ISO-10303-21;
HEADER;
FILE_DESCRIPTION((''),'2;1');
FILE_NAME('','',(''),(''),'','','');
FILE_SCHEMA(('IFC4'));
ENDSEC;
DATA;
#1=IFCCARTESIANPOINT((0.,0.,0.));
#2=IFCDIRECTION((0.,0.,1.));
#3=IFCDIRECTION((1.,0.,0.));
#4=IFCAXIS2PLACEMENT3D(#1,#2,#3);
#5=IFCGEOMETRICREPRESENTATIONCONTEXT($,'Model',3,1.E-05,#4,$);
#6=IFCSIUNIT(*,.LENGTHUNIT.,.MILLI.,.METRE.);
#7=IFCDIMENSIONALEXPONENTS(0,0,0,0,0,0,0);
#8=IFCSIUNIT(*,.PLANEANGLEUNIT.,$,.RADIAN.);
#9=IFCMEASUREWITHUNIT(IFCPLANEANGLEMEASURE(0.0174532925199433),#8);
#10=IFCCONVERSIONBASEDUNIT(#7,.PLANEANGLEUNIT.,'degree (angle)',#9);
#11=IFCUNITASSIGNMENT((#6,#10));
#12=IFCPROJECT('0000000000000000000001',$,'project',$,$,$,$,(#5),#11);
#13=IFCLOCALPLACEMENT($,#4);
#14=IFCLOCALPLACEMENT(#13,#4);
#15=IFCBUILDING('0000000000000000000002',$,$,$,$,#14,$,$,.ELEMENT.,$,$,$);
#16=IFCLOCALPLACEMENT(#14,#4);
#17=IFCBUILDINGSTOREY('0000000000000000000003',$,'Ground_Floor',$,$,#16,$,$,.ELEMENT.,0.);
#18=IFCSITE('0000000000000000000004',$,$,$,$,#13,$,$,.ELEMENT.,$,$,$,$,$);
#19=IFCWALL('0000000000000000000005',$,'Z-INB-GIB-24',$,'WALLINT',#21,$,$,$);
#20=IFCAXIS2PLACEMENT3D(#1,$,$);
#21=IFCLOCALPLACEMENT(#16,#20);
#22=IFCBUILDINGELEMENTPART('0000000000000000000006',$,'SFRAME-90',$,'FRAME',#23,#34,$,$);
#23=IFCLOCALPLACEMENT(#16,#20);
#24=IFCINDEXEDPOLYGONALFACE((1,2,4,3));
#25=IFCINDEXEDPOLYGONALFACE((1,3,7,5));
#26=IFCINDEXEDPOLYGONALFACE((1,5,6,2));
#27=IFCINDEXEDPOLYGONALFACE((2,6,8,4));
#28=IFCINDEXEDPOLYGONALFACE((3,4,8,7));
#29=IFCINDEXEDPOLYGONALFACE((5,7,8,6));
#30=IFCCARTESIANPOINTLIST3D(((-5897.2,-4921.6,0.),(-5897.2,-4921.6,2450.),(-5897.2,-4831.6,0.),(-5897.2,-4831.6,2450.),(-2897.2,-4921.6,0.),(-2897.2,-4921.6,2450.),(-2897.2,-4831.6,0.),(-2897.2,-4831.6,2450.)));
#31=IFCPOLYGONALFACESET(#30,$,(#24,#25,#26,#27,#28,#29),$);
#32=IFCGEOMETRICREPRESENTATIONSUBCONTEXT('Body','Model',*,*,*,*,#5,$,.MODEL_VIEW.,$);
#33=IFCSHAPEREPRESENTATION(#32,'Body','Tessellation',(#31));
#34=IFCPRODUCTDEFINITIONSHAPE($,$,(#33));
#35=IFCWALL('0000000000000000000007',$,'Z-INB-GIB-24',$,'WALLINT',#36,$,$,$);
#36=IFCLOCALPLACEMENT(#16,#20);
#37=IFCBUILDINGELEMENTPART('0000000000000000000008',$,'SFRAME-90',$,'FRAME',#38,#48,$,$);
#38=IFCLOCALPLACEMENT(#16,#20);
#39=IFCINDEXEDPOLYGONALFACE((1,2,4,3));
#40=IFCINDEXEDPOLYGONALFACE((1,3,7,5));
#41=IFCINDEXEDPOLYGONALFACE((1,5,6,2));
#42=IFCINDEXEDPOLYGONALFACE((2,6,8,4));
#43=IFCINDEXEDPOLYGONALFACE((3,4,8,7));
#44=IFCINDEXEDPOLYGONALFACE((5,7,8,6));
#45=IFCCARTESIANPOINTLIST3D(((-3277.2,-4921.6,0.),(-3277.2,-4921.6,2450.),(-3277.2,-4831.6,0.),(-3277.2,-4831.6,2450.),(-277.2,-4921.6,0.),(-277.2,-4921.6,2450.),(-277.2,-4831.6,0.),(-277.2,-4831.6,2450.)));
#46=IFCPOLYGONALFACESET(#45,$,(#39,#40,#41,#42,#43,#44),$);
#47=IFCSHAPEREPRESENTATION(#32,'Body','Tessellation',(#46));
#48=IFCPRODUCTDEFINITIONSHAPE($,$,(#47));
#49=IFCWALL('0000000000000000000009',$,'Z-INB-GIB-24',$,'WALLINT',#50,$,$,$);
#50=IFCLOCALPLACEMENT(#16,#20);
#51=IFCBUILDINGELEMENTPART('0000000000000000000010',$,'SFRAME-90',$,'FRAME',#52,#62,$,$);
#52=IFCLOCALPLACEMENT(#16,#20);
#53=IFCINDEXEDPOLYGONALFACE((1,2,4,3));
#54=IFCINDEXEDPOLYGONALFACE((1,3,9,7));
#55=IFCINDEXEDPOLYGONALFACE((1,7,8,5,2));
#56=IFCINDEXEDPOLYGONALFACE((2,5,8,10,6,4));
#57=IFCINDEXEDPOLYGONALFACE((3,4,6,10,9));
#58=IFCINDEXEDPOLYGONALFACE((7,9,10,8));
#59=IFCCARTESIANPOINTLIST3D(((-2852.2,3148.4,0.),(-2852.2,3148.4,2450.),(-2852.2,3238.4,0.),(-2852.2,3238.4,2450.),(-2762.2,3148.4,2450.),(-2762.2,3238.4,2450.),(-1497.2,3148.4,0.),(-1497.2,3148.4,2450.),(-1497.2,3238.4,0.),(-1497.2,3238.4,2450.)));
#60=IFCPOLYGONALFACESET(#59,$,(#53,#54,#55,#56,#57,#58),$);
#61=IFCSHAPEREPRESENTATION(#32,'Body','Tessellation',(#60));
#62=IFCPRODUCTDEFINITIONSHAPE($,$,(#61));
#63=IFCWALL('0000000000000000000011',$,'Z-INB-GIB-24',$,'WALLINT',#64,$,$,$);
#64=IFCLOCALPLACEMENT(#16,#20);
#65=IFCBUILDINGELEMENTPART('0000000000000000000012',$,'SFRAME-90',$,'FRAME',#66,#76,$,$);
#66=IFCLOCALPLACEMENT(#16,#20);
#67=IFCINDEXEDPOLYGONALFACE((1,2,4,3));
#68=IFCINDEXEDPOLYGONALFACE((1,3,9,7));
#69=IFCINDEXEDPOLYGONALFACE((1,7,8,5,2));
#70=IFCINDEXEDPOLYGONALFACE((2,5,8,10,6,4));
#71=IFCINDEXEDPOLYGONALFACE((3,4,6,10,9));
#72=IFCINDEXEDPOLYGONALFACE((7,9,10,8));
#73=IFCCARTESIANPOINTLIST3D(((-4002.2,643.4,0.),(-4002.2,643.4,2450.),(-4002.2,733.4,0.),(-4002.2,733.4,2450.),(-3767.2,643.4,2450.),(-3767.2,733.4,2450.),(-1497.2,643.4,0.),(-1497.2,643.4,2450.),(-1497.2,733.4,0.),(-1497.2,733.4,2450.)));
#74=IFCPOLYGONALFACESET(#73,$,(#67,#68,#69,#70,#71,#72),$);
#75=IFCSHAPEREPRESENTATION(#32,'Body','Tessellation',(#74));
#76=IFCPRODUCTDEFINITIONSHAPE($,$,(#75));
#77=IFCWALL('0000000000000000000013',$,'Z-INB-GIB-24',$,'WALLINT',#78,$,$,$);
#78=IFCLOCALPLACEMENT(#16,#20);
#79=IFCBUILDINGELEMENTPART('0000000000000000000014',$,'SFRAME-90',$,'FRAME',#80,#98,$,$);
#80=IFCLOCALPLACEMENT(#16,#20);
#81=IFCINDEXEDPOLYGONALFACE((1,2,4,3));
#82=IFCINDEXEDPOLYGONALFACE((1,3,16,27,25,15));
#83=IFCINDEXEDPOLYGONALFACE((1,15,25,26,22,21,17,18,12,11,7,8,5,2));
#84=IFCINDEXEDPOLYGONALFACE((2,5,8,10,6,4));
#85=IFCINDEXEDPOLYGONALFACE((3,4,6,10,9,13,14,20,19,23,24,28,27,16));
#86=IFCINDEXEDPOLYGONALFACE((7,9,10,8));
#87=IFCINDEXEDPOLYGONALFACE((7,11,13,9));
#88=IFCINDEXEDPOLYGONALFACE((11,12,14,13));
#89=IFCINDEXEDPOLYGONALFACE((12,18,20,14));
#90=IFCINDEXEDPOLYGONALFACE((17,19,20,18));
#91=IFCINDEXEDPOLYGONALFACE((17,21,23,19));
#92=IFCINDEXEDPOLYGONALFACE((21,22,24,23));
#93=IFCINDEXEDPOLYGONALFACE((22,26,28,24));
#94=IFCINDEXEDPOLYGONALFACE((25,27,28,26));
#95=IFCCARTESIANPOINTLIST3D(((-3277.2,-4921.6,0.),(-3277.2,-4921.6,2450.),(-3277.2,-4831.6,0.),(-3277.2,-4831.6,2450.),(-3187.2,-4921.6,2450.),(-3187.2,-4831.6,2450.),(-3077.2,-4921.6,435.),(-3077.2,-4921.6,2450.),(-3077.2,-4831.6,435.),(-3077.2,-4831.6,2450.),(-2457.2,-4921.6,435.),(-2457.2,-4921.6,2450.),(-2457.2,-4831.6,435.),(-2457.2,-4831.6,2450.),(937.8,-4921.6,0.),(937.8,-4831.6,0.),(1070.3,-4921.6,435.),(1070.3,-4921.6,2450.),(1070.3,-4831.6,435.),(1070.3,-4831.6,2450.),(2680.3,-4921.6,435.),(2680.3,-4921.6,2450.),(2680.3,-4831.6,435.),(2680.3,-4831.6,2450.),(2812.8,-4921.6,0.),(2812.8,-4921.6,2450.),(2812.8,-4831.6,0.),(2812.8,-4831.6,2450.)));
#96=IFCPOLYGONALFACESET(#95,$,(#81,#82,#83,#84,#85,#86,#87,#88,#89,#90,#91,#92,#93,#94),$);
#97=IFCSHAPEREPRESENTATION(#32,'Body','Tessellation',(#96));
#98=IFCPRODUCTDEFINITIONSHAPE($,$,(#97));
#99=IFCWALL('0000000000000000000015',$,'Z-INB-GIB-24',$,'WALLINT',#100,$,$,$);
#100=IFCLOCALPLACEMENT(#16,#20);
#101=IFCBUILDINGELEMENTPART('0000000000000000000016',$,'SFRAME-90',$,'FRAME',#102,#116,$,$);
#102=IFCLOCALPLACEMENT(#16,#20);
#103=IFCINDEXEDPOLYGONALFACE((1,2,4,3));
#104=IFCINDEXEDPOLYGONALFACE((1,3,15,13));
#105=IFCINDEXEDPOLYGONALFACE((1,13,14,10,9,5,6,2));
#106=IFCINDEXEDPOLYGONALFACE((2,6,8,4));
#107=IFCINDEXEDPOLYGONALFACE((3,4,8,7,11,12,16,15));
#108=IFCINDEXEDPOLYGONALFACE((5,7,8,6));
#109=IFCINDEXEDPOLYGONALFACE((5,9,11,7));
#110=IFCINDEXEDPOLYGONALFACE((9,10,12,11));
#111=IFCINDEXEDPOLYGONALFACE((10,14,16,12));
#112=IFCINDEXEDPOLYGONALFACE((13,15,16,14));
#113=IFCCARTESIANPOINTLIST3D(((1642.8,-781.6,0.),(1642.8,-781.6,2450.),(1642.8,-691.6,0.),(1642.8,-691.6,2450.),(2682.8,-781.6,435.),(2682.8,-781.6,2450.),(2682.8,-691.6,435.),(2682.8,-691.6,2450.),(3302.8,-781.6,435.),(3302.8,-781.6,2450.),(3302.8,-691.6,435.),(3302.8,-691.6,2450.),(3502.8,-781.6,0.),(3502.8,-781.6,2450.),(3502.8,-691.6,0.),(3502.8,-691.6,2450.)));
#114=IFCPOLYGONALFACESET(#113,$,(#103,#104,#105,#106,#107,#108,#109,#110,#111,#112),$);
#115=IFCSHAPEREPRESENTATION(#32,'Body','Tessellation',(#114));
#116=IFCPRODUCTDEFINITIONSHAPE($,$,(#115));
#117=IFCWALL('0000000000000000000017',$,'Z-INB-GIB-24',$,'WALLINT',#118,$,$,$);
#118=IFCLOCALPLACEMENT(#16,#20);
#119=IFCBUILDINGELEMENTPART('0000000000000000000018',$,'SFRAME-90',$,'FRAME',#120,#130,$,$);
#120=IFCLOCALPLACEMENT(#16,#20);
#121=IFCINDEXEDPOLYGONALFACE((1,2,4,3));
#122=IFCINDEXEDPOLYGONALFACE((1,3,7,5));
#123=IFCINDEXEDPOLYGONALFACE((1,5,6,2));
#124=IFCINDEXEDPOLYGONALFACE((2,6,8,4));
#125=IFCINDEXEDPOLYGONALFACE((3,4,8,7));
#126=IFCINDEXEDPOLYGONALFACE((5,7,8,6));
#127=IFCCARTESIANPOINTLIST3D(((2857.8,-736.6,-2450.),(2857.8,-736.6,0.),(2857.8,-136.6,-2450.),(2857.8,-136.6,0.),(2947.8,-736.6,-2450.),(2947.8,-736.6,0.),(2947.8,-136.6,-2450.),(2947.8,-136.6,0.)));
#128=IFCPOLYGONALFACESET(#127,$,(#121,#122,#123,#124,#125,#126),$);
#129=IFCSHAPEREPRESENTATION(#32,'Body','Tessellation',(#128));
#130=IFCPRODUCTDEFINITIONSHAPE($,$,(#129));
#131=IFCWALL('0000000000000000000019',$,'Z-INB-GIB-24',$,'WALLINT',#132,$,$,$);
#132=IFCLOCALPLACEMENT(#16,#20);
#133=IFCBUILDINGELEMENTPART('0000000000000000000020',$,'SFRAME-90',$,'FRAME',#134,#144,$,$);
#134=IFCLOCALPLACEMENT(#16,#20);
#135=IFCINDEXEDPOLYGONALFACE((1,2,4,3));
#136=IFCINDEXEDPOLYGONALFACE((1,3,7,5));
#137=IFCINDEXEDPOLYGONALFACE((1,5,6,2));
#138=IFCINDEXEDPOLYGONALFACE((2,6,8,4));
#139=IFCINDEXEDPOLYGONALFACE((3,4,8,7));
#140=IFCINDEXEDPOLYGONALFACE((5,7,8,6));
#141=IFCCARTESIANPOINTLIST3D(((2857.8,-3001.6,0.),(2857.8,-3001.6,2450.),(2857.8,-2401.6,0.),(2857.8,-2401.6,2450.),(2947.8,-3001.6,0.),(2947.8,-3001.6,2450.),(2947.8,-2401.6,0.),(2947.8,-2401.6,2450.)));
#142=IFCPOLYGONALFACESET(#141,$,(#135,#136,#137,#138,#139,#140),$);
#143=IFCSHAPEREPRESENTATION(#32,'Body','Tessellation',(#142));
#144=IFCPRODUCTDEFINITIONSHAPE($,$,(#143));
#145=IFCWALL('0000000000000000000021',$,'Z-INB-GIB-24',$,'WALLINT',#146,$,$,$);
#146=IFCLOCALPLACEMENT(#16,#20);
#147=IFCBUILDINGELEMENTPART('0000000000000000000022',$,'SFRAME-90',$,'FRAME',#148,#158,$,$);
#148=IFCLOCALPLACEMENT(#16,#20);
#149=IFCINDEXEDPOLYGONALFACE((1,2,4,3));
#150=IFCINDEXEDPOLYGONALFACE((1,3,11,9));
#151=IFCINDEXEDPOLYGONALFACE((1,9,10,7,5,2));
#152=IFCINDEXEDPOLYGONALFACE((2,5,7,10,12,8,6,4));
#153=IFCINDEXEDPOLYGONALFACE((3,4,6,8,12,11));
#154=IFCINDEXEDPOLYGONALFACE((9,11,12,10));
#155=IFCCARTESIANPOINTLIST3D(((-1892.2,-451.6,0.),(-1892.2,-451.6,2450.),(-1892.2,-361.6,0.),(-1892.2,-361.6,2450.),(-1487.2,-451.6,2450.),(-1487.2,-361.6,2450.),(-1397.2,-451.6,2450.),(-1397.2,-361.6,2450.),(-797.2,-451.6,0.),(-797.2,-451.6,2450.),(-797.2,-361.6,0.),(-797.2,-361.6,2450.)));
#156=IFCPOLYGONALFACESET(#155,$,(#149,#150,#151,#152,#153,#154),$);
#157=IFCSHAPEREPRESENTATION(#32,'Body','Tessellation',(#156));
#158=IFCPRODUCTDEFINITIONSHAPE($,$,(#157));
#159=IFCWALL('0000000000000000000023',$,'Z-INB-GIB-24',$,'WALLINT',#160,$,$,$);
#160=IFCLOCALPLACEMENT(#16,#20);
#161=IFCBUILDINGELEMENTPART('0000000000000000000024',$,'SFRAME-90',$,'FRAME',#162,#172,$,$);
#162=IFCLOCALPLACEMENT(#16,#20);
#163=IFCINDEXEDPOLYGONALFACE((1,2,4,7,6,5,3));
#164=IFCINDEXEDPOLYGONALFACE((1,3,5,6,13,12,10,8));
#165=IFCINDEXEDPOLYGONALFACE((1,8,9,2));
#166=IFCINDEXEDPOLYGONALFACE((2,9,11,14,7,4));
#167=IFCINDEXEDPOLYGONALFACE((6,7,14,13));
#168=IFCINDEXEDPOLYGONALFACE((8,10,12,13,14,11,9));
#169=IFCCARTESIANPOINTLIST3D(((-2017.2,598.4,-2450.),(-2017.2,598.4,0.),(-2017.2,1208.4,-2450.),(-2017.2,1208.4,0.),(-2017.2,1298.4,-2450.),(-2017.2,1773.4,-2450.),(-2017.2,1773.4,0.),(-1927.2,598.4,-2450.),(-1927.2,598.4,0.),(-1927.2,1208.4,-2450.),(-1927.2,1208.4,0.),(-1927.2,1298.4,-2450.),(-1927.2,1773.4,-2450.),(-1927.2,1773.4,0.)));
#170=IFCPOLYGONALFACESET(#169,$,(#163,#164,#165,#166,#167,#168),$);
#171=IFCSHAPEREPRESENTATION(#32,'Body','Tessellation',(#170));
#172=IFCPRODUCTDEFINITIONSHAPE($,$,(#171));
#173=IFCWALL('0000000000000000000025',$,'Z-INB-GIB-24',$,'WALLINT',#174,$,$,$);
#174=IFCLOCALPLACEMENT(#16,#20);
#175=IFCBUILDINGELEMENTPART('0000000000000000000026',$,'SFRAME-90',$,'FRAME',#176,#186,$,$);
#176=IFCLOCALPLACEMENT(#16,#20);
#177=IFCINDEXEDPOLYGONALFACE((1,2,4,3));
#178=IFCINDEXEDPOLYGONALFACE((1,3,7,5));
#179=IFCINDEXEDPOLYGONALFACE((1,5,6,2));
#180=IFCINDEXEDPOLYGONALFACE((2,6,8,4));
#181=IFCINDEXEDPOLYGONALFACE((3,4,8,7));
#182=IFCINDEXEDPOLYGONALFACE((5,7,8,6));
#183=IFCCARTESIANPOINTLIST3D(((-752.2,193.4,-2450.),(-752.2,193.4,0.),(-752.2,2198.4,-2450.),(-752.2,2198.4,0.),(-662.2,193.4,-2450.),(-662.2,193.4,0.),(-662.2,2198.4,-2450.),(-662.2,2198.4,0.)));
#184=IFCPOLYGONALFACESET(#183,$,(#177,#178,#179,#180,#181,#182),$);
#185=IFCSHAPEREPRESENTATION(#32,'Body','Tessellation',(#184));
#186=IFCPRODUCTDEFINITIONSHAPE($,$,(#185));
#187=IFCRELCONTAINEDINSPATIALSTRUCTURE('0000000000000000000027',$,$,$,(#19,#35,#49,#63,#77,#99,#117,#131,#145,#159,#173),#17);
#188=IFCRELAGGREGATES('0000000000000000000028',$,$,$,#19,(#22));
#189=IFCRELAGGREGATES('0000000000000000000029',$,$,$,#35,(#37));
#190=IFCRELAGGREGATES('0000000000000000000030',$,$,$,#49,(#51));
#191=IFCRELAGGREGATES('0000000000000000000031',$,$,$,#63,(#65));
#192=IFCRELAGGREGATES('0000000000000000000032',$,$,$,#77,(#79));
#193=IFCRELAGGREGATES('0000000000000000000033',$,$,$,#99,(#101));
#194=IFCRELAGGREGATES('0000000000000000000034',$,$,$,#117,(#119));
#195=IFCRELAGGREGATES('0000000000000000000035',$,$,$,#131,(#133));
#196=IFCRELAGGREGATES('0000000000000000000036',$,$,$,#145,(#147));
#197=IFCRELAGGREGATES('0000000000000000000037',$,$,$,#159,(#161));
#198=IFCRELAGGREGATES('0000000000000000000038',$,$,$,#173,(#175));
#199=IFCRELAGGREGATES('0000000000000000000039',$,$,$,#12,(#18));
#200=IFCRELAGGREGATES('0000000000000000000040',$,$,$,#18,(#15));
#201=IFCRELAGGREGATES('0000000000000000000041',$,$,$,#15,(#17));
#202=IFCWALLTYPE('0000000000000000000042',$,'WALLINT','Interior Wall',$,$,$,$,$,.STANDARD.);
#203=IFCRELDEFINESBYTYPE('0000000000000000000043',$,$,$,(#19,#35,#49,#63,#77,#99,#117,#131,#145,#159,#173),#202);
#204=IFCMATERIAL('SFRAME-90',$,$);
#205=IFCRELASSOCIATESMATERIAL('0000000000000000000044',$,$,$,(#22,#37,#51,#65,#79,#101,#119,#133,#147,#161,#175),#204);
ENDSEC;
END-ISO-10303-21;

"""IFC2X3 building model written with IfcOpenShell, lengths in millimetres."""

from ifc_helpers import new_model, entity, si_unit, converted_unit, frame, origin_with_axes, place, context, subcontext, project, spatial, polyline, segment, composite_curve, outline, extrude, material, type_object, element, aggregate, save


model = new_model("IFC2X3")

# Units and contexts
model_context = context("Model", 3, precision=1e-05, world=origin_with_axes())
body_context = subcontext(model_context, "Body", "Model", "MODEL_VIEW")
ifc_project = project(units=[si_unit("LENGTHUNIT", "METRE", prefix="MILLI"), converted_unit("PLANEANGLEUNIT", "degree (angle)", entity("IfcPlaneAngleMeasure", 0.0174532925199433), si_unit("PLANEANGLEUNIT", "RADIAN"), dimensions=[0, 0, 0, 0, 0, 0, 0])], contexts=[model_context])

# Site, building, storey
site_placement = place(None, origin_with_axes())
site = spatial("IfcSite", under=ifc_project, at=site_placement, CompositionType="ELEMENT")
building_placement = place(site_placement, origin_with_axes())
building = spatial("IfcBuilding", under=site, at=building_placement, CompositionType="ELEMENT")
storey_placement = place(building_placement, origin_with_axes())
storey = spatial("IfcBuildingStorey", under=building, at=storey_placement, Name="Ground_Floor", CompositionType="ELEMENT", Elevation=0.0)

# Walls, building element parts
wall_type = type_object("IfcWallType", Name="WALLINT", Description="Interior Wall", PredefinedType="STANDARD")
wall_1_placement = place(storey_placement, frame((-2897.2, -4876.6, 2450.0), z_axis=(0.0, 0.0, 1.0), x_axis=(-1.0, 0.0, 0.0)))
wall_1 = element("IfcWall", 1, at=wall_1_placement, inside=storey, type_object=wall_type, Name="Z-INB-GIB-24", ObjectType="WALLINT")
ifc_material = material(Name="SFRAME-90")
building_element_part_1_placement = place(wall_1_placement, origin_with_axes())
building_element_part_1 = element("IfcBuildingElementPart", 2, at=building_element_part_1_placement, material=ifc_material, Name="SFRAME-90", ObjectType="FRAME", context=body_context, shape_type="SweptSolid", body=[
    extrude(outline(composite_curve([segment(polyline([(0.0, 2450.0), (3000.0, 2450.0), (3000.0, 0.0), (0.0, 0.0), (0.0, 2450.0)]), True, "CONTINUOUS")], self_intersect=False)), frame((0.0, -45.0, 0.0), z_axis=(0.0, 1.0, 0.0), x_axis=(1.0, 0.0, 0.0)), (0.0, 0.0, 1.0), 90.0),
])
aggregate(wall_1, [building_element_part_1])
wall_2_placement = place(storey_placement, frame((-277.2, -4876.6, 2450.0), z_axis=(0.0, 0.0, 1.0), x_axis=(-1.0, 0.0, 0.0)))
wall_2 = element("IfcWall", 3, at=wall_2_placement, inside=storey, type_object=wall_type, Name="Z-INB-GIB-24", ObjectType="WALLINT")
building_element_part_2_placement = place(wall_2_placement, origin_with_axes())
building_element_part_2 = element("IfcBuildingElementPart", 4, at=building_element_part_2_placement, material=ifc_material, Name="SFRAME-90", ObjectType="FRAME", context=body_context, shape_type="SweptSolid", body=[
    extrude(outline(composite_curve([segment(polyline([(0.0, 2450.0), (3000.0, 2450.0), (3000.0, 0.0), (0.0, 0.0), (0.0, 2450.0)]), True, "CONTINUOUS")], self_intersect=False)), frame((0.0, -45.0, 0.0), z_axis=(0.0, 1.0, 0.0), x_axis=(1.0, 0.0, 0.0)), (0.0, 0.0, 1.0), 90.0),
])
aggregate(wall_2, [building_element_part_2])
wall_3_placement = place(storey_placement, frame((-1497.2, 3193.4, 2450.0), z_axis=(0.0, 0.0, 1.0), x_axis=(-1.0, 0.0, 0.0)))
wall_3 = element("IfcWall", 5, at=wall_3_placement, inside=storey, type_object=wall_type, Name="Z-INB-GIB-24", ObjectType="WALLINT")
building_element_part_3_placement = place(wall_3_placement, origin_with_axes())
building_element_part_3 = element("IfcBuildingElementPart", 6, at=building_element_part_3_placement, material=ifc_material, Name="SFRAME-90", ObjectType="FRAME", context=body_context, shape_type="SweptSolid", body=[
    extrude(outline(composite_curve([segment(polyline([(0.0, 0.0), (1265.0, 0.0), (1355.0, 0.0), (1355.0, 2450.0), (0.0, 2450.0), (0.0, 0.0)]), True, "CONTINUOUS")], self_intersect=False)), frame((0.0, -45.0, 0.0), z_axis=(0.0, 1.0, 0.0), x_axis=(1.0, 0.0, 0.0)), (0.0, 0.0, 1.0), 90.0),
])
aggregate(wall_3, [building_element_part_3])
wall_4_placement = place(storey_placement, frame((-1497.2, 688.4, 2450.0), z_axis=(0.0, 0.0, 1.0), x_axis=(-1.0, 0.0, 0.0)))
wall_4 = element("IfcWall", 7, at=wall_4_placement, inside=storey, type_object=wall_type, Name="Z-INB-GIB-24", ObjectType="WALLINT")
building_element_part_4_placement = place(wall_4_placement, origin_with_axes())
building_element_part_4 = element("IfcBuildingElementPart", 8, at=building_element_part_4_placement, material=ifc_material, Name="SFRAME-90", ObjectType="FRAME", context=body_context, shape_type="SweptSolid", body=[
    extrude(outline(composite_curve([segment(polyline([(0.0, 2450.0), (0.0, 0.0), (2270.0, 0.0), (2505.0, 0.0), (2505.0, 2450.0), (0.0, 2450.0)]), True, "CONTINUOUS")], self_intersect=False)), frame((0.0, -45.0, 0.0), z_axis=(0.0, 1.0, 0.0), x_axis=(1.0, 0.0, 0.0)), (0.0, 0.0, 1.0), 90.0),
])
aggregate(wall_4, [building_element_part_4])
wall_5_placement = place(storey_placement, frame((2812.8, -4876.6, 2450.0), z_axis=(0.0, 0.0, 1.0), x_axis=(-1.0, 0.0, 0.0)))
wall_5 = element("IfcWall", 9, at=wall_5_placement, inside=storey, type_object=wall_type, Name="Z-INB-GIB-24", ObjectType="WALLINT")
building_element_part_5_placement = place(wall_5_placement, origin_with_axes())
building_element_part_5 = element("IfcBuildingElementPart", 10, at=building_element_part_5_placement, material=ifc_material, Name="SFRAME-90", ObjectType="FRAME", context=body_context, shape_type="SweptSolid", body=[
    extrude(outline(composite_curve([segment(polyline([(0.0, 0.0), (132.5, 0.0), (132.5, 2015.0), (1742.5, 2015.0), (1742.5, 0.0), (5270.0, 0.0), (5270.0, 2015.0), (5890.0, 2015.0), (5890.0, 0.0), (6000.0, 0.0), (6090.0, 0.0), (6090.0, 2450.0), (1875.0, 2450.0), (0.0, 2450.0), (0.0, 0.0)]), True, "CONTINUOUS")], self_intersect=False)), frame((0.0, -45.0, 0.0), z_axis=(0.0, 1.0, 0.0), x_axis=(1.0, 0.0, 0.0)), (0.0, 0.0, 1.0), 90.0),
])
aggregate(wall_5, [building_element_part_5])
wall_6_placement = place(storey_placement, frame((3502.8, -736.6, 2450.0), z_axis=(0.0, 0.0, 1.0), x_axis=(-1.0, 0.0, 0.0)))
wall_6 = element("IfcWall", 11, at=wall_6_placement, inside=storey, type_object=wall_type, Name="Z-INB-GIB-24", ObjectType="WALLINT")
building_element_part_6_placement = place(wall_6_placement, origin_with_axes())
building_element_part_6 = element("IfcBuildingElementPart", 12, at=building_element_part_6_placement, material=ifc_material, Name="SFRAME-90", ObjectType="FRAME", context=body_context, shape_type="SweptSolid", body=[
    extrude(outline(composite_curve([segment(polyline([(0.0, 0.0), (200.0, 0.0), (200.0, 2015.0), (820.0, 2015.0), (820.0, 0.0), (1860.0, 0.0), (1860.0, 2450.0), (0.0, 2450.0), (0.0, 0.0)]), True, "CONTINUOUS")], self_intersect=False)), frame((0.0, -45.0, 0.0), z_axis=(0.0, 1.0, 0.0), x_axis=(1.0, 0.0, 0.0)), (0.0, 0.0, 1.0), 90.0),
])
aggregate(wall_6, [building_element_part_6])
wall_7_placement = place(storey_placement, frame((2902.8, -736.6, 0.0), z_axis=(0.0, 0.0, 1.0), x_axis=(0.0, 1.0, 0.0)))
wall_7 = element("IfcWall", 13, at=wall_7_placement, inside=storey, type_object=wall_type, Name="Z-INB-GIB-24", ObjectType="WALLINT")
building_element_part_7_placement = place(wall_7_placement, origin_with_axes())
building_element_part_7 = element("IfcBuildingElementPart", 14, at=building_element_part_7_placement, material=ifc_material, Name="SFRAME-90", ObjectType="FRAME", context=body_context, shape_type="SweptSolid", body=[
    extrude(outline(composite_curve([segment(polyline([(0.0, 2450.0), (0.0, 0.0), (600.0, 0.0), (600.0, 2450.0), (0.0, 2450.0)]), True, "CONTINUOUS")], self_intersect=False)), frame((0.0, -45.0, 0.0), z_axis=(0.0, 1.0, 0.0), x_axis=(1.0, 0.0, 0.0)), (0.0, 0.0, 1.0), 90.0),
])
aggregate(wall_7, [building_element_part_7])
wall_8_placement = place(storey_placement, frame((2902.8, -3001.6, 2450.0), z_axis=(0.0, 0.0, 1.0), x_axis=(0.0, 1.0, 0.0)))
wall_8 = element("IfcWall", 15, at=wall_8_placement, inside=storey, type_object=wall_type, Name="Z-INB-GIB-24", ObjectType="WALLINT")
building_element_part_8_placement = place(wall_8_placement, origin_with_axes())
building_element_part_8 = element("IfcBuildingElementPart", 16, at=building_element_part_8_placement, material=ifc_material, Name="SFRAME-90", ObjectType="FRAME", context=body_context, shape_type="SweptSolid", body=[
    extrude(outline(composite_curve([segment(polyline([(0.0, 0.0), (600.0, 0.0), (600.0, 2450.0), (0.0, 2450.0), (0.0, 0.0)]), True, "CONTINUOUS")], self_intersect=False)), frame((0.0, -45.0, 0.0), z_axis=(0.0, 1.0, 0.0), x_axis=(1.0, 0.0, 0.0)), (0.0, 0.0, 1.0), 90.0),
])
aggregate(wall_8, [building_element_part_8])
wall_9_placement = place(storey_placement, frame((-797.2, -406.6, 2450.0), z_axis=(0.0, 0.0, 1.0), x_axis=(-1.0, 0.0, 0.0)))
wall_9 = element("IfcWall", 17, at=wall_9_placement, inside=storey, type_object=wall_type, Name="Z-INB-GIB-24", ObjectType="WALLINT")
building_element_part_9_placement = place(wall_9_placement, origin_with_axes())
building_element_part_9 = element("IfcBuildingElementPart", 18, at=building_element_part_9_placement, material=ifc_material, Name="SFRAME-90", ObjectType="FRAME", context=body_context, shape_type="SweptSolid", body=[
    extrude(outline(composite_curve([segment(polyline([(0.0, 2450.0), (0.0, 0.0), (600.0, 0.0), (690.0, 0.0), (1095.0, 0.0), (1095.0, 2450.0), (0.0, 2450.0)]), True, "CONTINUOUS")], self_intersect=False)), frame((0.0, -45.0, 0.0), z_axis=(0.0, 1.0, 0.0), x_axis=(1.0, 0.0, 0.0)), (0.0, 0.0, 1.0), 90.0),
])
aggregate(wall_9, [building_element_part_9])
wall_10_placement = place(storey_placement, frame((-1972.2, 598.4, 0.0), z_axis=(0.0, 0.0, 1.0), x_axis=(0.0, 1.0, 0.0)))
wall_10 = element("IfcWall", 19, at=wall_10_placement, inside=storey, type_object=wall_type, Name="Z-INB-GIB-24", ObjectType="WALLINT")
building_element_part_10_placement = place(wall_10_placement, origin_with_axes())
building_element_part_10 = element("IfcBuildingElementPart", 20, at=building_element_part_10_placement, material=ifc_material, Name="SFRAME-90", ObjectType="FRAME", context=body_context, shape_type="SweptSolid", body=[
    extrude(outline(composite_curve([segment(polyline([(0.0, 2450.0), (0.0, 0.0), (610.0, 0.0), (1175.0, 0.0), (1175.0, 2450.0), (700.0, 2450.0), (610.0, 2450.0), (0.0, 2450.0)]), True, "CONTINUOUS")], self_intersect=False)), frame((0.0, -45.0, 0.0), z_axis=(0.0, 1.0, 0.0), x_axis=(1.0, 0.0, 0.0)), (0.0, 0.0, 1.0), 90.0),
])
aggregate(wall_10, [building_element_part_10])
wall_11_placement = place(storey_placement, frame((-707.2, 193.4, 0.0), z_axis=(0.0, 0.0, 1.0), x_axis=(0.0, 1.0, 0.0)))
wall_11 = element("IfcWall", 21, at=wall_11_placement, inside=storey, type_object=wall_type, Name="Z-INB-GIB-24", ObjectType="WALLINT")
building_element_part_11_placement = place(wall_11_placement, origin_with_axes())
building_element_part_11 = element("IfcBuildingElementPart", 22, at=building_element_part_11_placement, material=ifc_material, Name="SFRAME-90", ObjectType="FRAME", context=body_context, shape_type="SweptSolid", body=[
    extrude(outline(composite_curve([segment(polyline([(0.0, 2450.0), (0.0, 0.0), (2005.0, 0.0), (2005.0, 2450.0), (0.0, 2450.0)]), True, "CONTINUOUS")], self_intersect=False)), frame((0.0, -45.0, 0.0), z_axis=(0.0, 1.0, 0.0), x_axis=(1.0, 0.0, 0.0)), (0.0, 0.0, 1.0), 90.0),
])
aggregate(wall_11, [building_element_part_11])

save(model, "model.ifc")
